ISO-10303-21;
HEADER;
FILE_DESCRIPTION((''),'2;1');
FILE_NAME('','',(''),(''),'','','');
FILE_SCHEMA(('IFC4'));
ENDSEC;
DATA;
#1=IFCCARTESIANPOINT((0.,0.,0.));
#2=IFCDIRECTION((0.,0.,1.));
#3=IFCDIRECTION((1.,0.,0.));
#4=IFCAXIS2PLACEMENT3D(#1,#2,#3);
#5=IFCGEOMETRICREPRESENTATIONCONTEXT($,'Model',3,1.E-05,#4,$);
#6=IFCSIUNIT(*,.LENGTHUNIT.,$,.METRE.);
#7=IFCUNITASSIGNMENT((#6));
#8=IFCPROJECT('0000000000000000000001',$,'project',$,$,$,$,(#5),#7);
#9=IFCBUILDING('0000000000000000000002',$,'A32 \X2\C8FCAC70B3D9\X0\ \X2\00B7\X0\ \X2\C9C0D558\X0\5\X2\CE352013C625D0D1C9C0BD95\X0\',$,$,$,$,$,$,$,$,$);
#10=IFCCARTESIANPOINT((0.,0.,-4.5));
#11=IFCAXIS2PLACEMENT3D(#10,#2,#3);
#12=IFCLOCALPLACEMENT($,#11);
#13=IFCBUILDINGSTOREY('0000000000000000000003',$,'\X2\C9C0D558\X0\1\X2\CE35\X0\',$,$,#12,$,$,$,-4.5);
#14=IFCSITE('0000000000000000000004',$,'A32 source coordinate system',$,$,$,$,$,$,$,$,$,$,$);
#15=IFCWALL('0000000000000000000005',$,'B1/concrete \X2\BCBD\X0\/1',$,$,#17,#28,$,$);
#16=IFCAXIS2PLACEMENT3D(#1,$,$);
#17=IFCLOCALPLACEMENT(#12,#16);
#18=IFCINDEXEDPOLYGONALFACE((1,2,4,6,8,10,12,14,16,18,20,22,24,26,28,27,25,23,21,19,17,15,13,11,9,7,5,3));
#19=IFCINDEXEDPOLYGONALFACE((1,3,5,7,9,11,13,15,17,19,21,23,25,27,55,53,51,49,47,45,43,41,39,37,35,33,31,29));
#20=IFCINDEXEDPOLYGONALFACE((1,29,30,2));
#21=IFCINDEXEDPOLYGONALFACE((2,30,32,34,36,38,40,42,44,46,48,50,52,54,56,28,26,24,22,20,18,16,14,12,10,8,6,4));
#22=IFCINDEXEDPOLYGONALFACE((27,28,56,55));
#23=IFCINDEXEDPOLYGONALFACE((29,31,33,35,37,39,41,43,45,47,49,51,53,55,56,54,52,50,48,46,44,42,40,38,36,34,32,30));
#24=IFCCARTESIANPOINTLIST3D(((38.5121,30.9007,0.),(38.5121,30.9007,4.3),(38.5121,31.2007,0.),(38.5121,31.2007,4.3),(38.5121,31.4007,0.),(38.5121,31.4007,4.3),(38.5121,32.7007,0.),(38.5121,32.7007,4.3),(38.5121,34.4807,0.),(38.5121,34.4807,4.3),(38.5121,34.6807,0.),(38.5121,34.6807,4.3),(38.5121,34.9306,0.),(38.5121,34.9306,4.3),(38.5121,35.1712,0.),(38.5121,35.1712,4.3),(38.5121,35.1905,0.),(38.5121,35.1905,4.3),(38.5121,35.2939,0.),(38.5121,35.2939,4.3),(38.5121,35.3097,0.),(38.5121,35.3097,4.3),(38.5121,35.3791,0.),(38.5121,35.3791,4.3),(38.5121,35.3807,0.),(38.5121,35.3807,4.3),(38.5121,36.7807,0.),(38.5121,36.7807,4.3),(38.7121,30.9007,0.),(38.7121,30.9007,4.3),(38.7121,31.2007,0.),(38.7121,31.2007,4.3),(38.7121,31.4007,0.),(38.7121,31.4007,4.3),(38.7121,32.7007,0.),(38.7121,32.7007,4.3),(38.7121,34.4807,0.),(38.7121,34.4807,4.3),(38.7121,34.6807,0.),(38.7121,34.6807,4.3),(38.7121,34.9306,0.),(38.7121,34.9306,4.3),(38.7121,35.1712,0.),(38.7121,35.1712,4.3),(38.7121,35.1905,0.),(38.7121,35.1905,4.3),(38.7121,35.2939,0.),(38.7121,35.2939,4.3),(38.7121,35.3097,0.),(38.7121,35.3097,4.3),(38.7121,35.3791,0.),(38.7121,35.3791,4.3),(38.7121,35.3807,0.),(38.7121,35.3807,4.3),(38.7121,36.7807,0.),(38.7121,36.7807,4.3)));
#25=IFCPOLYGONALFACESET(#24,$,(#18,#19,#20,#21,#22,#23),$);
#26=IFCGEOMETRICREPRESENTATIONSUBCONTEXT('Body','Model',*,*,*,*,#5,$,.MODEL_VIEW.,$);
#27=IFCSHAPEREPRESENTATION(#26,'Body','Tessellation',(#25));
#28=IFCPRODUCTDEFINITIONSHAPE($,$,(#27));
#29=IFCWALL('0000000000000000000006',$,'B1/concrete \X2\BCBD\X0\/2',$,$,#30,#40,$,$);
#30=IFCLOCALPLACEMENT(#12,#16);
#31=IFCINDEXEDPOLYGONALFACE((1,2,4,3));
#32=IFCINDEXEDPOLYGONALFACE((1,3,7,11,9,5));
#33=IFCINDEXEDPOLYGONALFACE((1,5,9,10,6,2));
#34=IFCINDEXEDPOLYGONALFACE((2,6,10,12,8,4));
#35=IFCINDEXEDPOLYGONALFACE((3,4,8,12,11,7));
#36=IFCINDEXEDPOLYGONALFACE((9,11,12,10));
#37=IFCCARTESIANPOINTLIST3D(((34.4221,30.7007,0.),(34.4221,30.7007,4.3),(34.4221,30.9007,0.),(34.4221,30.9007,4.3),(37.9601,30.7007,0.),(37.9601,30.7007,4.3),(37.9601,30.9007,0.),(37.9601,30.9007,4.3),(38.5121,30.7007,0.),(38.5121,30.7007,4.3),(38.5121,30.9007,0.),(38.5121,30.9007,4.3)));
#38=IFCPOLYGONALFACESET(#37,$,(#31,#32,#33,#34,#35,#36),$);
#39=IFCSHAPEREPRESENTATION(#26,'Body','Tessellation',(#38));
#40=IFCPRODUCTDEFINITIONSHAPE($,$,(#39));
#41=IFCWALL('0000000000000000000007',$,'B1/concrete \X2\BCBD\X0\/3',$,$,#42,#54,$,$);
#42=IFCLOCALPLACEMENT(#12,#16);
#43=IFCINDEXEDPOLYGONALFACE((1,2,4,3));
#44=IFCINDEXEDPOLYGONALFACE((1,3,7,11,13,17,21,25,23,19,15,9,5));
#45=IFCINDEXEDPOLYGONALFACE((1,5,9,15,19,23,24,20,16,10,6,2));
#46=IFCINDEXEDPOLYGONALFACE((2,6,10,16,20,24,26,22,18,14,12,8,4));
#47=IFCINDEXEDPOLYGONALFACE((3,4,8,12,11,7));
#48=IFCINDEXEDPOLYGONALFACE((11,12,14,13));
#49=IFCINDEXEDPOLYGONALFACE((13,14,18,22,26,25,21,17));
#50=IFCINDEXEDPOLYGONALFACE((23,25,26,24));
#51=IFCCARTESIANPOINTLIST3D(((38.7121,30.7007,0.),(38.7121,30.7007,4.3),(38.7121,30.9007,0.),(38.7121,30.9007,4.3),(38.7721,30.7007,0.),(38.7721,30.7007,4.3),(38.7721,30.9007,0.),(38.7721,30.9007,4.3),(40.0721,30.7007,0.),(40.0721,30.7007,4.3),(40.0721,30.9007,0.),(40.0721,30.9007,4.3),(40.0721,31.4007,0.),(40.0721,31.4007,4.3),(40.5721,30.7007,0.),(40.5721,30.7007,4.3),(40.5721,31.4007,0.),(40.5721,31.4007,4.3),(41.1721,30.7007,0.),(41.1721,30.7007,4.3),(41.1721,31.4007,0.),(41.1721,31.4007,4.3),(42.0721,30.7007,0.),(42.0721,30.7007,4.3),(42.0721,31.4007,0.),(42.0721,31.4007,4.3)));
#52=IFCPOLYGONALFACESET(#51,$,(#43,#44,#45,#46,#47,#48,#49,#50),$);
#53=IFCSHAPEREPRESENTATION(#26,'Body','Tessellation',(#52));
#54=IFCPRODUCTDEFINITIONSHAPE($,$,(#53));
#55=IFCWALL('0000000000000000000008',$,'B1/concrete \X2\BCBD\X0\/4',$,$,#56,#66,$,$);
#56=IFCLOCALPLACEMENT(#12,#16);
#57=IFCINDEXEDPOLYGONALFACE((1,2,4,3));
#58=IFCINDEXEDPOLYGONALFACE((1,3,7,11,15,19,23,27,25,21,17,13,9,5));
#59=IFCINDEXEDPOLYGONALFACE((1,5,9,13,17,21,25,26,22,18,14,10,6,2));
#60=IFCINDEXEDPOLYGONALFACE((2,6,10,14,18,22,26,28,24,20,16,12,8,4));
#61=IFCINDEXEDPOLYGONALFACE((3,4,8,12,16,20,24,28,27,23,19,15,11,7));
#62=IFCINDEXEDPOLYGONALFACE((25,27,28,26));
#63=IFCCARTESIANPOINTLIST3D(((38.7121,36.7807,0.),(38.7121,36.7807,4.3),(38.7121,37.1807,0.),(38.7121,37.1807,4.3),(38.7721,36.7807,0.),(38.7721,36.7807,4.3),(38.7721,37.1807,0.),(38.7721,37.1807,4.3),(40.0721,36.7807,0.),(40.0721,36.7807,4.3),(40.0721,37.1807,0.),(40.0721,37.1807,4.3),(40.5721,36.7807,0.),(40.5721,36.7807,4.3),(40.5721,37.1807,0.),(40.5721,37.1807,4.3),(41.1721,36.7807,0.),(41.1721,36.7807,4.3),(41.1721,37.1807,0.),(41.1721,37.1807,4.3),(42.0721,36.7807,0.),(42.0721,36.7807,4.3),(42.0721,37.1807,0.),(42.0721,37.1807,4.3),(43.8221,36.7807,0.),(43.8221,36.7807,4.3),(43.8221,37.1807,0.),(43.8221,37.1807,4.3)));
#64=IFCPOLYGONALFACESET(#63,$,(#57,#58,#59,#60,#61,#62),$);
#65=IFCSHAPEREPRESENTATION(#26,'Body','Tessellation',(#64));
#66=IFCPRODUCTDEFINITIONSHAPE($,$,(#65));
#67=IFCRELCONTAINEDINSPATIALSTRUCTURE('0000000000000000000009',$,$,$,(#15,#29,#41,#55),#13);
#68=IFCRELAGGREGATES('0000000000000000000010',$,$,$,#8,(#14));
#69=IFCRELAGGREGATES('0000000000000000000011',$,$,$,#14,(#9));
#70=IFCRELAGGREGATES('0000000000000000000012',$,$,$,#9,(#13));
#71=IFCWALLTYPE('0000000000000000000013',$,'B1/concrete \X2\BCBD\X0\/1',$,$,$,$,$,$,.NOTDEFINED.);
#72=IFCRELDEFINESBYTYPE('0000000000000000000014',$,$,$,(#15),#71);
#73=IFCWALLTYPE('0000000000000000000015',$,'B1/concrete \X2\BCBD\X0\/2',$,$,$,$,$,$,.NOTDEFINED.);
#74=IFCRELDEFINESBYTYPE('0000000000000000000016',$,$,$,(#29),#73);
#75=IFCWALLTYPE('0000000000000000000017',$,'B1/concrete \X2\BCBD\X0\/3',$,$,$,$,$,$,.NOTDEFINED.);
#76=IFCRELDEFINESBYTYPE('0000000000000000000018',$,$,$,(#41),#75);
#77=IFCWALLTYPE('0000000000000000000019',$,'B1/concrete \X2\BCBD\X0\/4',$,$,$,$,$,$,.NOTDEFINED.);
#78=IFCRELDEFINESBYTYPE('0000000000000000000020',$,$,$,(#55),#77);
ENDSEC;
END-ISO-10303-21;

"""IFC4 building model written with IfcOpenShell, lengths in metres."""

from ifc_helpers import new_model, si_unit, frame, origin, origin_with_axes, place, context, subcontext, project, spatial, polyline, outline, extrude, source, transform, mapped, type_object, type_shapes, element, save


model = new_model("IFC4")

# Units and contexts
model_context = context("Model", 3, precision=1e-05, world=origin_with_axes())
body_context = subcontext(model_context, "Body", "Model", "MODEL_VIEW")
ifc_project = project(units=[si_unit("LENGTHUNIT", "METRE")], contexts=[model_context])

# Site, building, storey
site = spatial("IfcSite", under=ifc_project, Name="A32 source coordinate system")
building = spatial("IfcBuilding", under=site, Name="A32 주거동 · 지하5층–옥탑지붕")
storey_placement = place(None, frame((0.0, 0.0, -4.5), z_axis=(0.0, 0.0, 1.0), x_axis=(1.0, 0.0, 0.0)))
storey = spatial("IfcBuildingStorey", under=building, at=storey_placement, Name="지하1층", Elevation=-4.5)

# Walls
wall_type_1 = type_object("IfcWallType", Name="B1/concrete 벽/1", PredefinedType="NOTDEFINED")
shared_shape_1 = source(origin(), body_context, "Body", "SweptSolid", [
    extrude(outline(polyline([(38.7121, 35.3791), (38.7121, 35.3097), (38.7121, 35.2939), (38.7121, 35.1905), (38.7121, 35.1712), (38.7121, 34.9306), (38.7121, 34.6807), (38.7121, 34.4807), (38.7121, 32.7007), (38.7121, 31.4007), (38.7121, 31.2007), (38.7121, 30.9007), (38.5121, 30.9007), (38.5121, 31.2007), (38.5121, 31.4007), (38.5121, 32.7007), (38.5121, 34.4807), (38.5121, 34.6807), (38.5121, 34.9306), (38.5121, 35.1712), (38.5121, 35.1905), (38.5121, 35.2939), (38.5121, 35.3097), (38.5121, 35.3791), (38.5121, 35.3807), (38.5121, 36.7807), (38.7121, 36.7807), (38.7121, 35.3807), (38.7121, 35.3791)])), origin(), (0.0, 0.0, 1.0), 4.3),
])
type_shapes(wall_type_1, [shared_shape_1])
wall_1_placement = place(storey_placement, origin_with_axes())
element("IfcWall", 1, at=wall_1_placement, inside=storey, type_object=wall_type_1, Name="B1/concrete 벽/1", context=body_context, shape_type="MappedRepresentation", body=[
    mapped(shared_shape_1, transform((0.0, 0.0, 0.0), scale=1.0)),
])
wall_type_2 = type_object("IfcWallType", Name="B1/concrete 벽/2", PredefinedType="NOTDEFINED")
shared_shape_2 = source(origin(), body_context, "Body", "SweptSolid", [
    extrude(outline(polyline([(34.4221, 30.7007), (34.4221, 30.9007), (37.9601, 30.9007), (38.5121, 30.9007), (38.5121, 30.7007), (37.9601, 30.7007), (34.4221, 30.7007)])), origin(), (0.0, 0.0, 1.0), 4.3),
])
type_shapes(wall_type_2, [shared_shape_2])
wall_2_placement = place(storey_placement, origin_with_axes())
element("IfcWall", 2, at=wall_2_placement, inside=storey, type_object=wall_type_2, Name="B1/concrete 벽/2", context=body_context, shape_type="MappedRepresentation", body=[
    mapped(shared_shape_2, transform((0.0, 0.0, 0.0), scale=1.0)),
])
wall_type_3 = type_object("IfcWallType", Name="B1/concrete 벽/3", PredefinedType="NOTDEFINED")
shared_shape_3 = source(origin(), body_context, "Body", "SweptSolid", [
    extrude(outline(polyline([(40.0721, 31.4007), (40.5721, 31.4007), (41.1721, 31.4007), (42.0721, 31.4007), (42.0721, 30.7007), (41.1721, 30.7007), (40.5721, 30.7007), (40.0721, 30.7007), (38.7721, 30.7007), (38.7121, 30.7007), (38.7121, 30.9007), (38.7721, 30.9007), (40.0721, 30.9007), (40.0721, 31.4007)])), origin(), (0.0, 0.0, 1.0), 4.3),
])
type_shapes(wall_type_3, [shared_shape_3])
wall_3_placement = place(storey_placement, origin_with_axes())
element("IfcWall", 3, at=wall_3_placement, inside=storey, type_object=wall_type_3, Name="B1/concrete 벽/3", context=body_context, shape_type="MappedRepresentation", body=[
    mapped(shared_shape_3, transform((0.0, 0.0, 0.0), scale=1.0)),
])
wall_type_4 = type_object("IfcWallType", Name="B1/concrete 벽/4", PredefinedType="NOTDEFINED")
shared_shape_4 = source(origin(), body_context, "Body", "SweptSolid", [
    extrude(outline(polyline([(40.0721, 37.1807), (40.5721, 37.1807), (41.1721, 37.1807), (42.0721, 37.1807), (43.8221, 37.1807), (43.8221, 36.7807), (42.0721, 36.7807), (41.1721, 36.7807), (40.5721, 36.7807), (40.0721, 36.7807), (38.7721, 36.7807), (38.7121, 36.7807), (38.7121, 37.1807), (38.7721, 37.1807), (40.0721, 37.1807)])), origin(), (0.0, 0.0, 1.0), 4.3),
])
type_shapes(wall_type_4, [shared_shape_4])
wall_4_placement = place(storey_placement, origin_with_axes())
element("IfcWall", 4, at=wall_4_placement, inside=storey, type_object=wall_type_4, Name="B1/concrete 벽/4", context=body_context, shape_type="MappedRepresentation", body=[
    mapped(shared_shape_4, transform((0.0, 0.0, 0.0), scale=1.0)),
])

save(model, "model.ifc")
